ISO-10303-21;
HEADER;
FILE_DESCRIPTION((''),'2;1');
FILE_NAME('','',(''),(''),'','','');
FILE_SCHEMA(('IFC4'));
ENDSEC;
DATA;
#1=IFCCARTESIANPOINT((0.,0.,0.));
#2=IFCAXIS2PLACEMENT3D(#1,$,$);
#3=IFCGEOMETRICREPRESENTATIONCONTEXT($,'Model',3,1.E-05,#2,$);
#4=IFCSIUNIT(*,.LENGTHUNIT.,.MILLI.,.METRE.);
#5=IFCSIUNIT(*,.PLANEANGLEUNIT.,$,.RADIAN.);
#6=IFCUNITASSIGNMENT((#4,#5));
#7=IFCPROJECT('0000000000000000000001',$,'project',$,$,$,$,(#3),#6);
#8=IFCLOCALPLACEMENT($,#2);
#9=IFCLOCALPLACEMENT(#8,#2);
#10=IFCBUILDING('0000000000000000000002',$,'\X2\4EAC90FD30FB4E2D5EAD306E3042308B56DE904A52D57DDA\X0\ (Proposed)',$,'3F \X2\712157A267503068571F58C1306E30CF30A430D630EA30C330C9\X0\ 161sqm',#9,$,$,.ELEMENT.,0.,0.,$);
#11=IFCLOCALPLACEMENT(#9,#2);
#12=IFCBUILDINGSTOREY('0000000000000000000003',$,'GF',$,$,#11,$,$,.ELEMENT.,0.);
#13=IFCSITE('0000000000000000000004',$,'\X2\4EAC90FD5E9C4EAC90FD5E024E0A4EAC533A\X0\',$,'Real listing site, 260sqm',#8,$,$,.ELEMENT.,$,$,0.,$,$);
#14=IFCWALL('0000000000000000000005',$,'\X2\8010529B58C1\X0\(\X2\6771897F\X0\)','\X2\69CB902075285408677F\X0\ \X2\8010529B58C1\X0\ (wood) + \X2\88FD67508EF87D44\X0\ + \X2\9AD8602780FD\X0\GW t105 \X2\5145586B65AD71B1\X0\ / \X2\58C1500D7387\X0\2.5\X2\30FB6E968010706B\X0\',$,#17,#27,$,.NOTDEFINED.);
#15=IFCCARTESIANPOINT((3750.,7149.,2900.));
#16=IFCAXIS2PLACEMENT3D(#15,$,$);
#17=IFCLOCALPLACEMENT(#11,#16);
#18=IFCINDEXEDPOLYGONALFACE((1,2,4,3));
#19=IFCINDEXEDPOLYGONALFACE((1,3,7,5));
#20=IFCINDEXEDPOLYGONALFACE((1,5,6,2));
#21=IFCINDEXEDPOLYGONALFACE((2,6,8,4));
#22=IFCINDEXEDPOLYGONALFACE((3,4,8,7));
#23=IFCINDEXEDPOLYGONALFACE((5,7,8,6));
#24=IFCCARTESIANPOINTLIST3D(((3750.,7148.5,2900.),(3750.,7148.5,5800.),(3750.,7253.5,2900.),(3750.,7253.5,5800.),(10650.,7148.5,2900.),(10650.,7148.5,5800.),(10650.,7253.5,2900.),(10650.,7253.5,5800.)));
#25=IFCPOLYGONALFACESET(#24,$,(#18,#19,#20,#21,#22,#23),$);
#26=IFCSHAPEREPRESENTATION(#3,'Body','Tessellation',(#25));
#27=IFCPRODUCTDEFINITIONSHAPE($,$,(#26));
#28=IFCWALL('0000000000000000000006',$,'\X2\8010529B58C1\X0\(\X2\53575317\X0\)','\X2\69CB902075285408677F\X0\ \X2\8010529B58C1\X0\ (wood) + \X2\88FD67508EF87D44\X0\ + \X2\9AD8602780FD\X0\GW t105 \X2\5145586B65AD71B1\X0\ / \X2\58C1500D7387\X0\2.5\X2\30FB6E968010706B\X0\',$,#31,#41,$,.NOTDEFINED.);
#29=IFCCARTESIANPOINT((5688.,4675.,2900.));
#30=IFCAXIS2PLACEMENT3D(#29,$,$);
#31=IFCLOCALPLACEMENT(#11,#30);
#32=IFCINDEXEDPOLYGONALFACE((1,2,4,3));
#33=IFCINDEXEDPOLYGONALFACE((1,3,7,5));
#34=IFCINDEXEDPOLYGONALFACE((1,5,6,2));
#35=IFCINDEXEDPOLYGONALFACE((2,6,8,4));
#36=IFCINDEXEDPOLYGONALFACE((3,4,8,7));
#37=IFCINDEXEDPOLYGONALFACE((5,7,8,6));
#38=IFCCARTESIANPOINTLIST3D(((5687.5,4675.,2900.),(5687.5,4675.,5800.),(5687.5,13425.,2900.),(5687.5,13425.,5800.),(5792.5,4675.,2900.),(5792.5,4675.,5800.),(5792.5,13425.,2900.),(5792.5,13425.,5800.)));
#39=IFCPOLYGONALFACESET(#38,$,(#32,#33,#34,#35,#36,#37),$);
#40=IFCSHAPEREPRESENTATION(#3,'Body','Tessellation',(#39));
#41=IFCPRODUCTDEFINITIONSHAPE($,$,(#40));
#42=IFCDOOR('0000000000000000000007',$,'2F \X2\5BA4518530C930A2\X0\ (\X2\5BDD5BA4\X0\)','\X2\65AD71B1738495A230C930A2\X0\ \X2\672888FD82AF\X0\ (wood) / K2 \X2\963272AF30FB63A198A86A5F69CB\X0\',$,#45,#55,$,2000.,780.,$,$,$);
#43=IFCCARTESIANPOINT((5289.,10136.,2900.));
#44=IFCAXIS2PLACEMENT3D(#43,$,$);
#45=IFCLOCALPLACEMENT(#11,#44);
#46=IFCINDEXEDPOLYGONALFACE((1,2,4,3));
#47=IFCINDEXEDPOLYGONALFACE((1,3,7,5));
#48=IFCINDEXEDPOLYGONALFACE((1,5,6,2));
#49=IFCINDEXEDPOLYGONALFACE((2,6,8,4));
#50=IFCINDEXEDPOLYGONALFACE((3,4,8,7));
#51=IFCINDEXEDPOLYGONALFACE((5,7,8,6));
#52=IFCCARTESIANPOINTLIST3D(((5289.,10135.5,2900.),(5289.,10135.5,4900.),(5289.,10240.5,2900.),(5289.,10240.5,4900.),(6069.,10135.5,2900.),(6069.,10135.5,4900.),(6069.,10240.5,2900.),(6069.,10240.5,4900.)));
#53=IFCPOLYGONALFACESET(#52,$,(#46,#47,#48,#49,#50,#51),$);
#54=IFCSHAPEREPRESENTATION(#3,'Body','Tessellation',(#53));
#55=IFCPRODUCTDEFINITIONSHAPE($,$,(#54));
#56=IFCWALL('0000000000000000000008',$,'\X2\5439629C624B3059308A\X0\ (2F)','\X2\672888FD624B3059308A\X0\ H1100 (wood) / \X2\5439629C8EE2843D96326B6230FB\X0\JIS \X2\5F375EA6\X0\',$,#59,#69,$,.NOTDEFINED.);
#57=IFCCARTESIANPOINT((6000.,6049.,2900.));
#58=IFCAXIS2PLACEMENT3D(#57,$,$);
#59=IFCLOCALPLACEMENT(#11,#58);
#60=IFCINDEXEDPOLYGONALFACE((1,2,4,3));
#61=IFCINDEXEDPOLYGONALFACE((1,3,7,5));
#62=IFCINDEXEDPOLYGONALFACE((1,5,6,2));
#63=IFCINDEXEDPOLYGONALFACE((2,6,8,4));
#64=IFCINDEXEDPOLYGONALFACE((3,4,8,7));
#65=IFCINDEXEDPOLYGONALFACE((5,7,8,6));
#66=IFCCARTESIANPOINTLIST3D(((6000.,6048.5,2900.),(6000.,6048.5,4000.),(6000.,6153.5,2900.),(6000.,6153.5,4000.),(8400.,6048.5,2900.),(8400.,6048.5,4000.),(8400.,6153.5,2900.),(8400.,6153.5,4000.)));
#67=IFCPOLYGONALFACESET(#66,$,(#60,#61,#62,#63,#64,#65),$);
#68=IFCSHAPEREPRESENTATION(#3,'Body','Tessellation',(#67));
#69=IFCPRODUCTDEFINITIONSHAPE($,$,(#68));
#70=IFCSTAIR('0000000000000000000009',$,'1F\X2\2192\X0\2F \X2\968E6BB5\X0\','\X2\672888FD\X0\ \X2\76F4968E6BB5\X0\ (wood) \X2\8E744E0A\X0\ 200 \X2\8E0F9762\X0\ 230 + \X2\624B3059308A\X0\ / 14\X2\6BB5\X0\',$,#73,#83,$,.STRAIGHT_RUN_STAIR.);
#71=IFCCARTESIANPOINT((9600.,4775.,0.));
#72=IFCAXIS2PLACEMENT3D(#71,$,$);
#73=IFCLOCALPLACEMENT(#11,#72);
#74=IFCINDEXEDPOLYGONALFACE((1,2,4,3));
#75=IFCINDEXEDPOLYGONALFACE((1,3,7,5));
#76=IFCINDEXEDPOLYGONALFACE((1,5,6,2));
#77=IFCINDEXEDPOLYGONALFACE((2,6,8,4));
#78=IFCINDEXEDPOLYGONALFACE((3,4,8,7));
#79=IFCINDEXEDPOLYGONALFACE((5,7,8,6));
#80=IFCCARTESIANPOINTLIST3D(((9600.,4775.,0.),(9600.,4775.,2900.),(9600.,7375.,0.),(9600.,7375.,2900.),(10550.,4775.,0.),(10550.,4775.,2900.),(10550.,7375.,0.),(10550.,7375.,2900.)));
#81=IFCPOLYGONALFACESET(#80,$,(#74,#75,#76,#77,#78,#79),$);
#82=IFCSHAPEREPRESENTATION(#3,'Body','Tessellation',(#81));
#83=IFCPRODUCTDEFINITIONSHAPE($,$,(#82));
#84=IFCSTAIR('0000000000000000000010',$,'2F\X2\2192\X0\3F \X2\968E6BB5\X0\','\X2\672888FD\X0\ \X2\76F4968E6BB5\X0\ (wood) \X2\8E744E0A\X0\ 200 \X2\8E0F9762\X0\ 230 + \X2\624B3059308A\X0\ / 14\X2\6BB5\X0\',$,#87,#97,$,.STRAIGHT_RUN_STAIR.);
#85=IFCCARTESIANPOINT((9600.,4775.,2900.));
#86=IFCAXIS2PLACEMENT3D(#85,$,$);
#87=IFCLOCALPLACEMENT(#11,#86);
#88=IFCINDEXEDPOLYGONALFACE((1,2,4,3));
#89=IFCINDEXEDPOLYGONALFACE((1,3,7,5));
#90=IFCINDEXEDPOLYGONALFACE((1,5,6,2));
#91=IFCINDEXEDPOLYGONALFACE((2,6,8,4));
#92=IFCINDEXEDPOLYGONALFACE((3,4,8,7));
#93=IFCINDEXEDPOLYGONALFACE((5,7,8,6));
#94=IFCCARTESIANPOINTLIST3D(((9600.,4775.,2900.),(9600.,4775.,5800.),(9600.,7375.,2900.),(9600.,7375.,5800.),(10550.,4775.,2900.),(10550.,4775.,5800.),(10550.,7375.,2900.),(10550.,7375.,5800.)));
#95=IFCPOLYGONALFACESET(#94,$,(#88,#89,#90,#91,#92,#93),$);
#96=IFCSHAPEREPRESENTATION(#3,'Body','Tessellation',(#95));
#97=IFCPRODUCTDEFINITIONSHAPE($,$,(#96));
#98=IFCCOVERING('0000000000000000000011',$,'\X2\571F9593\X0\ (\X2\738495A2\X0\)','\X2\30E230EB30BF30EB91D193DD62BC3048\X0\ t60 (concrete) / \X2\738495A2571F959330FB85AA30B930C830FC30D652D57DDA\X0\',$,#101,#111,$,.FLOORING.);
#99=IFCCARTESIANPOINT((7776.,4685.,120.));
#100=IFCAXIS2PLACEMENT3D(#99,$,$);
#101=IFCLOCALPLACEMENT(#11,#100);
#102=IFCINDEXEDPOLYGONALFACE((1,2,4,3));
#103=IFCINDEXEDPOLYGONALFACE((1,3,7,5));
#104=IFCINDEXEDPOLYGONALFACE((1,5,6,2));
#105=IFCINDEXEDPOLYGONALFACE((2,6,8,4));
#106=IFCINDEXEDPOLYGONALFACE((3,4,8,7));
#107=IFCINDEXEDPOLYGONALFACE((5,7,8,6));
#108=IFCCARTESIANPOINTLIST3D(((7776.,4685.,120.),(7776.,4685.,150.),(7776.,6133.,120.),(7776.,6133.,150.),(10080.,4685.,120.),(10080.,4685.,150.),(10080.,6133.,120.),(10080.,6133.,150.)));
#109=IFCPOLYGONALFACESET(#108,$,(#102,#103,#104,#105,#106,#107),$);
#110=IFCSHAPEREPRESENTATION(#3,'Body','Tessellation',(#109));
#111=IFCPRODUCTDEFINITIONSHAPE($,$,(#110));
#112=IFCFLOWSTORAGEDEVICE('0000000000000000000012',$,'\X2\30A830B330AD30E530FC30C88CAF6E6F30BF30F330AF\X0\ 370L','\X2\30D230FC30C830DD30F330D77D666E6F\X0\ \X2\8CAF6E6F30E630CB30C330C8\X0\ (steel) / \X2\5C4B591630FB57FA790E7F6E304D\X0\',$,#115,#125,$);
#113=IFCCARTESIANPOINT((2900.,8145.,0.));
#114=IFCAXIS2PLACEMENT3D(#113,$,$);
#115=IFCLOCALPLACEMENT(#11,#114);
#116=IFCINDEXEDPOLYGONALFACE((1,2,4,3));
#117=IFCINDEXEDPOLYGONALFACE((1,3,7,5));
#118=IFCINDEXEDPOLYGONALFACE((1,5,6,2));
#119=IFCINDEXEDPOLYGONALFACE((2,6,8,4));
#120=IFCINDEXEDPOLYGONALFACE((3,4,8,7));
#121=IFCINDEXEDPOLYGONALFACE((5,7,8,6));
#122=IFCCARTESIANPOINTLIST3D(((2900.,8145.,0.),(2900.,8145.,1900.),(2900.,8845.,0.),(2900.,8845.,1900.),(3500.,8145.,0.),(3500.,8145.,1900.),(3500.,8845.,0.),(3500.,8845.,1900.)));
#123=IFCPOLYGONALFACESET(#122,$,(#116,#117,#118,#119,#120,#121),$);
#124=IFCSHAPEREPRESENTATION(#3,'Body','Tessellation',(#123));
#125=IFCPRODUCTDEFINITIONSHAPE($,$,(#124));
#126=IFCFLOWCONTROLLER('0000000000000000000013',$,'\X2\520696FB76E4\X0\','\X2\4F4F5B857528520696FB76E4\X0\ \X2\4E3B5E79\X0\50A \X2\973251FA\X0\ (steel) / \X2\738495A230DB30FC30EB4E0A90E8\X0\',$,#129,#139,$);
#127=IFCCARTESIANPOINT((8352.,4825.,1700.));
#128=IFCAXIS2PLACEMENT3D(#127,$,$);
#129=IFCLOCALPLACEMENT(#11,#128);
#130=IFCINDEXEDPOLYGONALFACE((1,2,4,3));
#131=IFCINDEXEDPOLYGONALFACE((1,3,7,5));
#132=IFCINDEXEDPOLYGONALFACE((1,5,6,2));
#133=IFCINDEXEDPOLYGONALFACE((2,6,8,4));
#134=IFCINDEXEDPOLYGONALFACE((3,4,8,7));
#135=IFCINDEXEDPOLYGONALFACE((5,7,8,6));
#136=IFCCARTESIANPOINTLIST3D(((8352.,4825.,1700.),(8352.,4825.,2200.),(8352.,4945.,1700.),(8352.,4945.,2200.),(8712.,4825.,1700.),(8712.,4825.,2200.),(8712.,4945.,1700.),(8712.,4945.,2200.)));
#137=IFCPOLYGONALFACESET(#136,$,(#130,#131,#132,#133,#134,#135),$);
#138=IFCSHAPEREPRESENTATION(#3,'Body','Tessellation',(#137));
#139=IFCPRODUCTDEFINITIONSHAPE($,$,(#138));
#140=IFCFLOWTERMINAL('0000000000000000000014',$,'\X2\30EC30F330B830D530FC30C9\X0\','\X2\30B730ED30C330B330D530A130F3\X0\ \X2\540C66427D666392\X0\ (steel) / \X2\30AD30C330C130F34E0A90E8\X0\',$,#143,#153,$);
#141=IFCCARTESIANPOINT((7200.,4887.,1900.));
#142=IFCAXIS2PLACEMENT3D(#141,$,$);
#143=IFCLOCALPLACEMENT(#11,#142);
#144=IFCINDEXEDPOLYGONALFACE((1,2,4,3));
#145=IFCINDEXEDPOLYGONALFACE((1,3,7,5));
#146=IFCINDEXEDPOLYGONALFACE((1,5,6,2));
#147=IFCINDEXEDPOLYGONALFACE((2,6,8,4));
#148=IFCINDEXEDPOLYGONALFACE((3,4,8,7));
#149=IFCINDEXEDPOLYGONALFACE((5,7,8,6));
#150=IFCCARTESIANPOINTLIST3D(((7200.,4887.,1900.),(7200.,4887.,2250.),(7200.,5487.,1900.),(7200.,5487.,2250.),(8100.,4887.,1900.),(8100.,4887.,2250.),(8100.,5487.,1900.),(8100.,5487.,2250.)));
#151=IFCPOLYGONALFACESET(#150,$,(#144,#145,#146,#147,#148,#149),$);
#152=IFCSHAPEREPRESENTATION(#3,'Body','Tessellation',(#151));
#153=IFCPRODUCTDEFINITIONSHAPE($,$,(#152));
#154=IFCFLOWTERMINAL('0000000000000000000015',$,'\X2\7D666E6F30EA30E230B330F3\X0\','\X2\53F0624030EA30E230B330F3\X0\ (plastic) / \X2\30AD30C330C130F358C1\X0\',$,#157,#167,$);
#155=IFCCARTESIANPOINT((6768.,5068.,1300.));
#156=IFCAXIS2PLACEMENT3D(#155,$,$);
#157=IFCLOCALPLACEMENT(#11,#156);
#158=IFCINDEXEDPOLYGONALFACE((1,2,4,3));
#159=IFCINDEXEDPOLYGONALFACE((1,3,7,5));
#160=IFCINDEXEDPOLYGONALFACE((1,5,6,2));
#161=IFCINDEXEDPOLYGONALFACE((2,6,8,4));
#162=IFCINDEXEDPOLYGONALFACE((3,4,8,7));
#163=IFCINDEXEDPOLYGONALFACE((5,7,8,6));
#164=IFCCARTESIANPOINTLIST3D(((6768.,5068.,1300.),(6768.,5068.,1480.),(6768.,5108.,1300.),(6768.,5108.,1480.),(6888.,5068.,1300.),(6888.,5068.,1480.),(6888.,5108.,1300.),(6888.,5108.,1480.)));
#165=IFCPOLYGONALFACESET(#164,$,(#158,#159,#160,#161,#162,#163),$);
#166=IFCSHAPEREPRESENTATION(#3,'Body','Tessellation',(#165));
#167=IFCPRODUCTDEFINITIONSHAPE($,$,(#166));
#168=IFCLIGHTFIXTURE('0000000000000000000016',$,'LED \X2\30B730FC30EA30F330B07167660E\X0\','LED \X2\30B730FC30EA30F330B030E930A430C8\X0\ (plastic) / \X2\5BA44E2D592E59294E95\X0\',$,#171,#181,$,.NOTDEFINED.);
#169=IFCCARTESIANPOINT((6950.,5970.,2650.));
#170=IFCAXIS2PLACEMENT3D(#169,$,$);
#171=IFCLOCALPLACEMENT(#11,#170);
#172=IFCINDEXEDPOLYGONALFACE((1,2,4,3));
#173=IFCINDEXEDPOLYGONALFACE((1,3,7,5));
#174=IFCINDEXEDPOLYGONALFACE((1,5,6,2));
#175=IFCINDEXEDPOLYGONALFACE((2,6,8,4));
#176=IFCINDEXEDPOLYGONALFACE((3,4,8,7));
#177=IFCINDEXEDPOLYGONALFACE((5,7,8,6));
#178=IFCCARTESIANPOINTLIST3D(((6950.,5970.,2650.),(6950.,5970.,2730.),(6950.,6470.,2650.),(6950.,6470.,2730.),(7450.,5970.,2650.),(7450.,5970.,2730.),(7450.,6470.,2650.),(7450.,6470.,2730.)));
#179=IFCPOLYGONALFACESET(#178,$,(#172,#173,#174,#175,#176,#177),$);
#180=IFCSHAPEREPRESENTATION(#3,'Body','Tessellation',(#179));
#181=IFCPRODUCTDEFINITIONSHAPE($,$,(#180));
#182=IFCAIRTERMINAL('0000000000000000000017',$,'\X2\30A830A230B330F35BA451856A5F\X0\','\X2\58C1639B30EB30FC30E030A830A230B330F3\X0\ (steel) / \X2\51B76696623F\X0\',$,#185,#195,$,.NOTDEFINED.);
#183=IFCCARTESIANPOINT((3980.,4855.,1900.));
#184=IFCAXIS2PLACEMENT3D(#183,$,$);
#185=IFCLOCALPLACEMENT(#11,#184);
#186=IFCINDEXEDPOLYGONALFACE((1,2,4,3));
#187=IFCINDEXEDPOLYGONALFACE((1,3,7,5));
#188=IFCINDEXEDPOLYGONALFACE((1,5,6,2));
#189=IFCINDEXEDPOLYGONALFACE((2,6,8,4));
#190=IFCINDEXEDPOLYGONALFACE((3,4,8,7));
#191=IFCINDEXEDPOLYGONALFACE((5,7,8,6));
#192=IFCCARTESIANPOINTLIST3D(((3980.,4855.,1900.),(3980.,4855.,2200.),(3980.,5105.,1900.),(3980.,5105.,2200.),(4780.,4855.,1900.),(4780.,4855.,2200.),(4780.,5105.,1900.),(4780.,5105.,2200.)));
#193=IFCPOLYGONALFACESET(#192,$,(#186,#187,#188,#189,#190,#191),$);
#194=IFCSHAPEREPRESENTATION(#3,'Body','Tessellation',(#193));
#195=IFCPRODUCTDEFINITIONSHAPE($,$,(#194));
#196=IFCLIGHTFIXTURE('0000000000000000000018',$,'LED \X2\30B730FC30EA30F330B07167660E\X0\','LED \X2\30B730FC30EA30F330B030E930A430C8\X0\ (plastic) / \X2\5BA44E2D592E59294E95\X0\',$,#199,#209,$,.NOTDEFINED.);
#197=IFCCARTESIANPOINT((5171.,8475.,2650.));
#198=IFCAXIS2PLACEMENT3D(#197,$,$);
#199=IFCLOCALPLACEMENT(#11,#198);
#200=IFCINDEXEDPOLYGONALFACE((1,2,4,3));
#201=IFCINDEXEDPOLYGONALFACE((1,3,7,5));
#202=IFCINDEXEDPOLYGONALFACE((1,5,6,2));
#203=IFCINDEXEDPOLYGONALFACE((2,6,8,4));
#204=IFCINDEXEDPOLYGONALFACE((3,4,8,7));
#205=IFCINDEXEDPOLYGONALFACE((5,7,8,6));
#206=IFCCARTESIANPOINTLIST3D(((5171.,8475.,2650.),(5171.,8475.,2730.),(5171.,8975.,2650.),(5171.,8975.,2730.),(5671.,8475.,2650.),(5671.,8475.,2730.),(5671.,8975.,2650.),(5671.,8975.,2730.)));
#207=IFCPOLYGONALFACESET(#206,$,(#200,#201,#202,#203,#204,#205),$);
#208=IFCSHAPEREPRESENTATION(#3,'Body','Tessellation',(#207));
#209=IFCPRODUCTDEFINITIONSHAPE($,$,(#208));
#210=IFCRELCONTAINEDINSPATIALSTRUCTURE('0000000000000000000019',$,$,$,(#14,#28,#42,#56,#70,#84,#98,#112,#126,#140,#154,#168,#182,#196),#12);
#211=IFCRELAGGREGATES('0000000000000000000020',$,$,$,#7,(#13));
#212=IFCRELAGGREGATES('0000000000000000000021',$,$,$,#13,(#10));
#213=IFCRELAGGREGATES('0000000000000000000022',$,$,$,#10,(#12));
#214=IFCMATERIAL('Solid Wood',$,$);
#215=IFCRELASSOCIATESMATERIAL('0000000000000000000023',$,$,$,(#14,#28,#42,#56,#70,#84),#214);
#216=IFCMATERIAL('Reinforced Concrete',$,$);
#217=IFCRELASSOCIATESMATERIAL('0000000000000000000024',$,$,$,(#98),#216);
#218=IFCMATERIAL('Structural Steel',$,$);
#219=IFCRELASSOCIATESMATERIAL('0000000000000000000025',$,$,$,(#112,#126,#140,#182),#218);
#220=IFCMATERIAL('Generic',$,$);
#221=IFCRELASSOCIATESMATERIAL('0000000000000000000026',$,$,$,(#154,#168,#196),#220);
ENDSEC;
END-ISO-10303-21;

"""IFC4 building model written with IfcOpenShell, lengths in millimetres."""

from ifc_helpers import new_model, si_unit, frame, frame_2d, origin, place, context, project, spatial, rectangle, extrude, material, element, fill, save


model = new_model("IFC4")

# Units and contexts
model_context = context("Model", 3, precision=1e-05, world=origin())
ifc_project = project(units=[si_unit("LENGTHUNIT", "METRE", prefix="MILLI"), si_unit("PLANEANGLEUNIT", "RADIAN")], contexts=[model_context])

# Site, building, storey
site_placement = place(None, origin())
site = spatial("IfcSite", under=ifc_project, at=site_placement, Name="京都府京都市上京区", ObjectType="Real listing site, 260sqm", CompositionType="ELEMENT", RefElevation=0.0)
building_placement = place(site_placement, origin())
building = spatial("IfcBuilding", under=site, at=building_placement, Name="京都・中庭のある回遊動線 (Proposed)", ObjectType="3F 無垢材と土壁のハイブリッド 161sqm", CompositionType="ELEMENT", ElevationOfRefHeight=0.0, ElevationOfTerrain=0.0)
storey_placement = place(building_placement, origin())
storey = spatial("IfcBuildingStorey", under=building, at=storey_placement, Name="GF", CompositionType="ELEMENT", Elevation=0.0)

# Shared definitions
ifc_material_1 = material(Name="Solid Wood")

# Wall
wall_1_placement = place(storey_placement, frame((3750.0, 7149.0, 2900.0)))
element("IfcWall", 1, at=wall_1_placement, inside=storey, material=ifc_material_1, Name="耐力壁(東西)", Description="構造用合板 耐力壁 (wood) + 製材軸組 + 高性能GW t105 充填断熱 / 壁倍率2.5・準耐火", PredefinedType="NOTDEFINED", context=model_context, shape_type="SweptSolid", body=[
    extrude(rectangle(XDim=6900.0, YDim=105.0, at=frame_2d((3450.0, 52.0))), frame((3750.0, 7149.0, 2900.0)), (0.0, 0.0, 1.0), 2900.0),
])

# Wall, opening, door
wall_2_placement = place(storey_placement, frame((5688.0, 4675.0, 2900.0)))
wall_2 = element("IfcWall", 2, at=wall_2_placement, inside=storey, material=ifc_material_1, Name="耐力壁(南北)", Description="構造用合板 耐力壁 (wood) + 製材軸組 + 高性能GW t105 充填断熱 / 壁倍率2.5・準耐火", PredefinedType="NOTDEFINED", context=model_context, shape_type="SweptSolid", body=[
    extrude(rectangle(XDim=105.0, YDim=8750.0, at=frame_2d((52.0, 4375.0))), frame((5688.0, 4675.0, 2900.0)), (0.0, 0.0, 1.0), 2900.0),
])
opening_placement = place(storey_placement, frame((5289.0, 10136.0, 2900.0)))
opening = element("IfcOpeningElement", 3, at=opening_placement, cuts=wall_2, PredefinedType="NOTDEFINED", context=model_context, shape_type="SweptSolid", body=[
    extrude(rectangle(XDim=780.0, YDim=105.0, at=frame_2d((390.0, 52.0))), frame((5289.0, 10136.0, 2900.0)), (0.0, 0.0, 1.0), 2000.0),
])
door_placement = place(storey_placement, frame((5289.0, 10136.0, 2900.0)))
door = element("IfcDoor", 4, at=door_placement, inside=storey, material=ifc_material_1, Name="2F 室内ドア (寝室)", Description="断熱玄関ドア 木製芯 (wood) / K2 防犯・採風機構", OverallHeight=2000.0, OverallWidth=780.0, context=model_context, shape_type="SweptSolid", body=[
    extrude(rectangle(XDim=780.0, YDim=105.0, at=frame_2d((390.0, 52.0))), frame((5289.0, 10136.0, 2900.0)), (0.0, 0.0, 1.0), 2000.0),
])
fill(opening, door)

# Wall
wall_3_placement = place(storey_placement, frame((6000.0, 6049.0, 2900.0)))
element("IfcWall", 5, at=wall_3_placement, inside=storey, material=ifc_material_1, Name="吹抜手すり (2F)", Description="木製手すり H1100 (wood) / 吹抜転落防止・JIS 強度", PredefinedType="NOTDEFINED", context=model_context, shape_type="SweptSolid", body=[
    extrude(rectangle(XDim=2400.0, YDim=105.0, at=frame_2d((1200.0, 52.0))), frame((6000.0, 6049.0, 2900.0)), (0.0, 0.0, 1.0), 1100.0),
])

# Stairs
stair_1_placement = place(storey_placement, frame((9600.0, 4775.0, 0.0)))
element("IfcStair", 6, at=stair_1_placement, inside=storey, material=ifc_material_1, Name="1F→2F 階段", Description="木製 直階段 (wood) 蹴上 200 踏面 230 + 手すり / 14段", PredefinedType="STRAIGHT_RUN_STAIR", context=model_context, shape_type="SweptSolid", body=[
    extrude(rectangle(XDim=950.0, YDim=2600.0, at=frame_2d((475.0, 1300.0))), frame((9600.0, 4775.0, 0.0)), (0.0, 0.0, 1.0), 2900.0),
])
stair_2_placement = place(storey_placement, frame((9600.0, 4775.0, 2900.0)))
element("IfcStair", 7, at=stair_2_placement, inside=storey, material=ifc_material_1, Name="2F→3F 階段", Description="木製 直階段 (wood) 蹴上 200 踏面 230 + 手すり / 14段", PredefinedType="STRAIGHT_RUN_STAIR", context=model_context, shape_type="SweptSolid", body=[
    extrude(rectangle(XDim=950.0, YDim=2600.0, at=frame_2d((475.0, 1300.0))), frame((9600.0, 4775.0, 2900.0)), (0.0, 0.0, 1.0), 2900.0),
])

# Covering
ifc_material_2 = material(Name="Reinforced Concrete")
covering_placement = place(storey_placement, frame((7776.0, 4685.0, 120.0)))
element("IfcCovering", 8, at=covering_placement, inside=storey, material=ifc_material_2, Name="土間 (玄関)", Description="モルタル金鏝押え t60 (concrete) / 玄関土間・薪ストーブ動線", PredefinedType="FLOORING", context=model_context, shape_type="SweptSolid", body=[
    extrude(rectangle(XDim=2304.0, YDim=1448.0, at=frame_2d((1152.0, 724.0))), frame((7776.0, 4685.0, 120.0)), (0.0, 0.0, 1.0), 30.0),
])

# Flow storage device
ifc_material_3 = material(Name="Structural Steel")
flow_storage_device_placement = place(storey_placement, frame((2900.0, 8145.0, 0.0)))
element("IfcFlowStorageDevice", 9, at=flow_storage_device_placement, inside=storey, material=ifc_material_3, Name="エコキュート貯湯タンク 370L", Description="ヒートポンプ給湯 貯湯ユニット (steel) / 屋外・基礎置き", context=model_context, shape_type="SweptSolid", body=[
    extrude(rectangle(XDim=600.0, YDim=700.0, at=frame_2d((300.0, 350.0))), frame((2900.0, 8145.0, 0.0)), (0.0, 0.0, 1.0), 1900.0),
])

# Flow controller
flow_controller_placement = place(storey_placement, frame((8352.0, 4825.0, 1700.0)))
element("IfcFlowController", 10, at=flow_controller_placement, inside=storey, material=ifc_material_3, Name="分電盤", Description="住宅用分電盤 主幹50A 露出 (steel) / 玄関ホール上部", context=model_context, shape_type="SweptSolid", body=[
    extrude(rectangle(XDim=360.0, YDim=120.0, at=frame_2d((180.0, 60.0))), frame((8352.0, 4825.0, 1700.0)), (0.0, 0.0, 1.0), 500.0),
])

# Flow terminals
flow_terminal_1_placement = place(storey_placement, frame((7200.0, 4887.0, 1900.0)))
element("IfcFlowTerminal", 11, at=flow_terminal_1_placement, inside=storey, material=ifc_material_3, Name="レンジフード", Description="シロッコファン 同時給排 (steel) / キッチン上部", context=model_context, shape_type="SweptSolid", body=[
    extrude(rectangle(XDim=900.0, YDim=600.0, at=frame_2d((450.0, 300.0))), frame((7200.0, 4887.0, 1900.0)), (0.0, 0.0, 1.0), 350.0),
])
ifc_material_4 = material(Name="Generic")
flow_terminal_2_placement = place(storey_placement, frame((6768.0, 5068.0, 1300.0)))
element("IfcFlowTerminal", 12, at=flow_terminal_2_placement, inside=storey, material=ifc_material_4, Name="給湯リモコン", Description="台所リモコン (plastic) / キッチン壁", context=model_context, shape_type="SweptSolid", body=[
    extrude(rectangle(XDim=120.0, YDim=40.0, at=frame_2d((60.0, 20.0))), frame((6768.0, 5068.0, 1300.0)), (0.0, 0.0, 1.0), 180.0),
])

# Light fixture
light_fixture_1_placement = place(storey_placement, frame((6950.0, 5970.0, 2650.0)))
element("IfcLightFixture", 13, at=light_fixture_1_placement, inside=storey, material=ifc_material_4, Name="LED シーリング照明", Description="LED シーリングライト (plastic) / 室中央天井", PredefinedType="NOTDEFINED", context=model_context, shape_type="SweptSolid", body=[
    extrude(rectangle(XDim=500.0, YDim=500.0, at=frame_2d((250.0, 250.0))), frame((6950.0, 5970.0, 2650.0)), (0.0, 0.0, 1.0), 80.0),
])

# Air terminal
air_terminal_1_placement = place(storey_placement, frame((3980.0, 4855.0, 1900.0)))
element("IfcAirTerminal", 14, at=air_terminal_1_placement, inside=storey, material=ifc_material_3, Name="エアコン室内機", Description="壁掛ルームエアコン (steel) / 冷暖房", PredefinedType="NOTDEFINED", context=model_context, shape_type="SweptSolid", body=[
    extrude(rectangle(XDim=800.0, YDim=250.0, at=frame_2d((400.0, 125.0))), frame((3980.0, 4855.0, 1900.0)), (0.0, 0.0, 1.0), 300.0),
])

# Light fixture
light_fixture_2_placement = place(storey_placement, frame((5171.0, 8475.0, 2650.0)))
element("IfcLightFixture", 15, at=light_fixture_2_placement, inside=storey, material=ifc_material_4, Name="LED シーリング照明", Description="LED シーリングライト (plastic) / 室中央天井", PredefinedType="NOTDEFINED", context=model_context, shape_type="SweptSolid", body=[
    extrude(rectangle(XDim=500.0, YDim=500.0, at=frame_2d((250.0, 250.0))), frame((5171.0, 8475.0, 2650.0)), (0.0, 0.0, 1.0), 80.0),
])

save(model, "model.ifc")
